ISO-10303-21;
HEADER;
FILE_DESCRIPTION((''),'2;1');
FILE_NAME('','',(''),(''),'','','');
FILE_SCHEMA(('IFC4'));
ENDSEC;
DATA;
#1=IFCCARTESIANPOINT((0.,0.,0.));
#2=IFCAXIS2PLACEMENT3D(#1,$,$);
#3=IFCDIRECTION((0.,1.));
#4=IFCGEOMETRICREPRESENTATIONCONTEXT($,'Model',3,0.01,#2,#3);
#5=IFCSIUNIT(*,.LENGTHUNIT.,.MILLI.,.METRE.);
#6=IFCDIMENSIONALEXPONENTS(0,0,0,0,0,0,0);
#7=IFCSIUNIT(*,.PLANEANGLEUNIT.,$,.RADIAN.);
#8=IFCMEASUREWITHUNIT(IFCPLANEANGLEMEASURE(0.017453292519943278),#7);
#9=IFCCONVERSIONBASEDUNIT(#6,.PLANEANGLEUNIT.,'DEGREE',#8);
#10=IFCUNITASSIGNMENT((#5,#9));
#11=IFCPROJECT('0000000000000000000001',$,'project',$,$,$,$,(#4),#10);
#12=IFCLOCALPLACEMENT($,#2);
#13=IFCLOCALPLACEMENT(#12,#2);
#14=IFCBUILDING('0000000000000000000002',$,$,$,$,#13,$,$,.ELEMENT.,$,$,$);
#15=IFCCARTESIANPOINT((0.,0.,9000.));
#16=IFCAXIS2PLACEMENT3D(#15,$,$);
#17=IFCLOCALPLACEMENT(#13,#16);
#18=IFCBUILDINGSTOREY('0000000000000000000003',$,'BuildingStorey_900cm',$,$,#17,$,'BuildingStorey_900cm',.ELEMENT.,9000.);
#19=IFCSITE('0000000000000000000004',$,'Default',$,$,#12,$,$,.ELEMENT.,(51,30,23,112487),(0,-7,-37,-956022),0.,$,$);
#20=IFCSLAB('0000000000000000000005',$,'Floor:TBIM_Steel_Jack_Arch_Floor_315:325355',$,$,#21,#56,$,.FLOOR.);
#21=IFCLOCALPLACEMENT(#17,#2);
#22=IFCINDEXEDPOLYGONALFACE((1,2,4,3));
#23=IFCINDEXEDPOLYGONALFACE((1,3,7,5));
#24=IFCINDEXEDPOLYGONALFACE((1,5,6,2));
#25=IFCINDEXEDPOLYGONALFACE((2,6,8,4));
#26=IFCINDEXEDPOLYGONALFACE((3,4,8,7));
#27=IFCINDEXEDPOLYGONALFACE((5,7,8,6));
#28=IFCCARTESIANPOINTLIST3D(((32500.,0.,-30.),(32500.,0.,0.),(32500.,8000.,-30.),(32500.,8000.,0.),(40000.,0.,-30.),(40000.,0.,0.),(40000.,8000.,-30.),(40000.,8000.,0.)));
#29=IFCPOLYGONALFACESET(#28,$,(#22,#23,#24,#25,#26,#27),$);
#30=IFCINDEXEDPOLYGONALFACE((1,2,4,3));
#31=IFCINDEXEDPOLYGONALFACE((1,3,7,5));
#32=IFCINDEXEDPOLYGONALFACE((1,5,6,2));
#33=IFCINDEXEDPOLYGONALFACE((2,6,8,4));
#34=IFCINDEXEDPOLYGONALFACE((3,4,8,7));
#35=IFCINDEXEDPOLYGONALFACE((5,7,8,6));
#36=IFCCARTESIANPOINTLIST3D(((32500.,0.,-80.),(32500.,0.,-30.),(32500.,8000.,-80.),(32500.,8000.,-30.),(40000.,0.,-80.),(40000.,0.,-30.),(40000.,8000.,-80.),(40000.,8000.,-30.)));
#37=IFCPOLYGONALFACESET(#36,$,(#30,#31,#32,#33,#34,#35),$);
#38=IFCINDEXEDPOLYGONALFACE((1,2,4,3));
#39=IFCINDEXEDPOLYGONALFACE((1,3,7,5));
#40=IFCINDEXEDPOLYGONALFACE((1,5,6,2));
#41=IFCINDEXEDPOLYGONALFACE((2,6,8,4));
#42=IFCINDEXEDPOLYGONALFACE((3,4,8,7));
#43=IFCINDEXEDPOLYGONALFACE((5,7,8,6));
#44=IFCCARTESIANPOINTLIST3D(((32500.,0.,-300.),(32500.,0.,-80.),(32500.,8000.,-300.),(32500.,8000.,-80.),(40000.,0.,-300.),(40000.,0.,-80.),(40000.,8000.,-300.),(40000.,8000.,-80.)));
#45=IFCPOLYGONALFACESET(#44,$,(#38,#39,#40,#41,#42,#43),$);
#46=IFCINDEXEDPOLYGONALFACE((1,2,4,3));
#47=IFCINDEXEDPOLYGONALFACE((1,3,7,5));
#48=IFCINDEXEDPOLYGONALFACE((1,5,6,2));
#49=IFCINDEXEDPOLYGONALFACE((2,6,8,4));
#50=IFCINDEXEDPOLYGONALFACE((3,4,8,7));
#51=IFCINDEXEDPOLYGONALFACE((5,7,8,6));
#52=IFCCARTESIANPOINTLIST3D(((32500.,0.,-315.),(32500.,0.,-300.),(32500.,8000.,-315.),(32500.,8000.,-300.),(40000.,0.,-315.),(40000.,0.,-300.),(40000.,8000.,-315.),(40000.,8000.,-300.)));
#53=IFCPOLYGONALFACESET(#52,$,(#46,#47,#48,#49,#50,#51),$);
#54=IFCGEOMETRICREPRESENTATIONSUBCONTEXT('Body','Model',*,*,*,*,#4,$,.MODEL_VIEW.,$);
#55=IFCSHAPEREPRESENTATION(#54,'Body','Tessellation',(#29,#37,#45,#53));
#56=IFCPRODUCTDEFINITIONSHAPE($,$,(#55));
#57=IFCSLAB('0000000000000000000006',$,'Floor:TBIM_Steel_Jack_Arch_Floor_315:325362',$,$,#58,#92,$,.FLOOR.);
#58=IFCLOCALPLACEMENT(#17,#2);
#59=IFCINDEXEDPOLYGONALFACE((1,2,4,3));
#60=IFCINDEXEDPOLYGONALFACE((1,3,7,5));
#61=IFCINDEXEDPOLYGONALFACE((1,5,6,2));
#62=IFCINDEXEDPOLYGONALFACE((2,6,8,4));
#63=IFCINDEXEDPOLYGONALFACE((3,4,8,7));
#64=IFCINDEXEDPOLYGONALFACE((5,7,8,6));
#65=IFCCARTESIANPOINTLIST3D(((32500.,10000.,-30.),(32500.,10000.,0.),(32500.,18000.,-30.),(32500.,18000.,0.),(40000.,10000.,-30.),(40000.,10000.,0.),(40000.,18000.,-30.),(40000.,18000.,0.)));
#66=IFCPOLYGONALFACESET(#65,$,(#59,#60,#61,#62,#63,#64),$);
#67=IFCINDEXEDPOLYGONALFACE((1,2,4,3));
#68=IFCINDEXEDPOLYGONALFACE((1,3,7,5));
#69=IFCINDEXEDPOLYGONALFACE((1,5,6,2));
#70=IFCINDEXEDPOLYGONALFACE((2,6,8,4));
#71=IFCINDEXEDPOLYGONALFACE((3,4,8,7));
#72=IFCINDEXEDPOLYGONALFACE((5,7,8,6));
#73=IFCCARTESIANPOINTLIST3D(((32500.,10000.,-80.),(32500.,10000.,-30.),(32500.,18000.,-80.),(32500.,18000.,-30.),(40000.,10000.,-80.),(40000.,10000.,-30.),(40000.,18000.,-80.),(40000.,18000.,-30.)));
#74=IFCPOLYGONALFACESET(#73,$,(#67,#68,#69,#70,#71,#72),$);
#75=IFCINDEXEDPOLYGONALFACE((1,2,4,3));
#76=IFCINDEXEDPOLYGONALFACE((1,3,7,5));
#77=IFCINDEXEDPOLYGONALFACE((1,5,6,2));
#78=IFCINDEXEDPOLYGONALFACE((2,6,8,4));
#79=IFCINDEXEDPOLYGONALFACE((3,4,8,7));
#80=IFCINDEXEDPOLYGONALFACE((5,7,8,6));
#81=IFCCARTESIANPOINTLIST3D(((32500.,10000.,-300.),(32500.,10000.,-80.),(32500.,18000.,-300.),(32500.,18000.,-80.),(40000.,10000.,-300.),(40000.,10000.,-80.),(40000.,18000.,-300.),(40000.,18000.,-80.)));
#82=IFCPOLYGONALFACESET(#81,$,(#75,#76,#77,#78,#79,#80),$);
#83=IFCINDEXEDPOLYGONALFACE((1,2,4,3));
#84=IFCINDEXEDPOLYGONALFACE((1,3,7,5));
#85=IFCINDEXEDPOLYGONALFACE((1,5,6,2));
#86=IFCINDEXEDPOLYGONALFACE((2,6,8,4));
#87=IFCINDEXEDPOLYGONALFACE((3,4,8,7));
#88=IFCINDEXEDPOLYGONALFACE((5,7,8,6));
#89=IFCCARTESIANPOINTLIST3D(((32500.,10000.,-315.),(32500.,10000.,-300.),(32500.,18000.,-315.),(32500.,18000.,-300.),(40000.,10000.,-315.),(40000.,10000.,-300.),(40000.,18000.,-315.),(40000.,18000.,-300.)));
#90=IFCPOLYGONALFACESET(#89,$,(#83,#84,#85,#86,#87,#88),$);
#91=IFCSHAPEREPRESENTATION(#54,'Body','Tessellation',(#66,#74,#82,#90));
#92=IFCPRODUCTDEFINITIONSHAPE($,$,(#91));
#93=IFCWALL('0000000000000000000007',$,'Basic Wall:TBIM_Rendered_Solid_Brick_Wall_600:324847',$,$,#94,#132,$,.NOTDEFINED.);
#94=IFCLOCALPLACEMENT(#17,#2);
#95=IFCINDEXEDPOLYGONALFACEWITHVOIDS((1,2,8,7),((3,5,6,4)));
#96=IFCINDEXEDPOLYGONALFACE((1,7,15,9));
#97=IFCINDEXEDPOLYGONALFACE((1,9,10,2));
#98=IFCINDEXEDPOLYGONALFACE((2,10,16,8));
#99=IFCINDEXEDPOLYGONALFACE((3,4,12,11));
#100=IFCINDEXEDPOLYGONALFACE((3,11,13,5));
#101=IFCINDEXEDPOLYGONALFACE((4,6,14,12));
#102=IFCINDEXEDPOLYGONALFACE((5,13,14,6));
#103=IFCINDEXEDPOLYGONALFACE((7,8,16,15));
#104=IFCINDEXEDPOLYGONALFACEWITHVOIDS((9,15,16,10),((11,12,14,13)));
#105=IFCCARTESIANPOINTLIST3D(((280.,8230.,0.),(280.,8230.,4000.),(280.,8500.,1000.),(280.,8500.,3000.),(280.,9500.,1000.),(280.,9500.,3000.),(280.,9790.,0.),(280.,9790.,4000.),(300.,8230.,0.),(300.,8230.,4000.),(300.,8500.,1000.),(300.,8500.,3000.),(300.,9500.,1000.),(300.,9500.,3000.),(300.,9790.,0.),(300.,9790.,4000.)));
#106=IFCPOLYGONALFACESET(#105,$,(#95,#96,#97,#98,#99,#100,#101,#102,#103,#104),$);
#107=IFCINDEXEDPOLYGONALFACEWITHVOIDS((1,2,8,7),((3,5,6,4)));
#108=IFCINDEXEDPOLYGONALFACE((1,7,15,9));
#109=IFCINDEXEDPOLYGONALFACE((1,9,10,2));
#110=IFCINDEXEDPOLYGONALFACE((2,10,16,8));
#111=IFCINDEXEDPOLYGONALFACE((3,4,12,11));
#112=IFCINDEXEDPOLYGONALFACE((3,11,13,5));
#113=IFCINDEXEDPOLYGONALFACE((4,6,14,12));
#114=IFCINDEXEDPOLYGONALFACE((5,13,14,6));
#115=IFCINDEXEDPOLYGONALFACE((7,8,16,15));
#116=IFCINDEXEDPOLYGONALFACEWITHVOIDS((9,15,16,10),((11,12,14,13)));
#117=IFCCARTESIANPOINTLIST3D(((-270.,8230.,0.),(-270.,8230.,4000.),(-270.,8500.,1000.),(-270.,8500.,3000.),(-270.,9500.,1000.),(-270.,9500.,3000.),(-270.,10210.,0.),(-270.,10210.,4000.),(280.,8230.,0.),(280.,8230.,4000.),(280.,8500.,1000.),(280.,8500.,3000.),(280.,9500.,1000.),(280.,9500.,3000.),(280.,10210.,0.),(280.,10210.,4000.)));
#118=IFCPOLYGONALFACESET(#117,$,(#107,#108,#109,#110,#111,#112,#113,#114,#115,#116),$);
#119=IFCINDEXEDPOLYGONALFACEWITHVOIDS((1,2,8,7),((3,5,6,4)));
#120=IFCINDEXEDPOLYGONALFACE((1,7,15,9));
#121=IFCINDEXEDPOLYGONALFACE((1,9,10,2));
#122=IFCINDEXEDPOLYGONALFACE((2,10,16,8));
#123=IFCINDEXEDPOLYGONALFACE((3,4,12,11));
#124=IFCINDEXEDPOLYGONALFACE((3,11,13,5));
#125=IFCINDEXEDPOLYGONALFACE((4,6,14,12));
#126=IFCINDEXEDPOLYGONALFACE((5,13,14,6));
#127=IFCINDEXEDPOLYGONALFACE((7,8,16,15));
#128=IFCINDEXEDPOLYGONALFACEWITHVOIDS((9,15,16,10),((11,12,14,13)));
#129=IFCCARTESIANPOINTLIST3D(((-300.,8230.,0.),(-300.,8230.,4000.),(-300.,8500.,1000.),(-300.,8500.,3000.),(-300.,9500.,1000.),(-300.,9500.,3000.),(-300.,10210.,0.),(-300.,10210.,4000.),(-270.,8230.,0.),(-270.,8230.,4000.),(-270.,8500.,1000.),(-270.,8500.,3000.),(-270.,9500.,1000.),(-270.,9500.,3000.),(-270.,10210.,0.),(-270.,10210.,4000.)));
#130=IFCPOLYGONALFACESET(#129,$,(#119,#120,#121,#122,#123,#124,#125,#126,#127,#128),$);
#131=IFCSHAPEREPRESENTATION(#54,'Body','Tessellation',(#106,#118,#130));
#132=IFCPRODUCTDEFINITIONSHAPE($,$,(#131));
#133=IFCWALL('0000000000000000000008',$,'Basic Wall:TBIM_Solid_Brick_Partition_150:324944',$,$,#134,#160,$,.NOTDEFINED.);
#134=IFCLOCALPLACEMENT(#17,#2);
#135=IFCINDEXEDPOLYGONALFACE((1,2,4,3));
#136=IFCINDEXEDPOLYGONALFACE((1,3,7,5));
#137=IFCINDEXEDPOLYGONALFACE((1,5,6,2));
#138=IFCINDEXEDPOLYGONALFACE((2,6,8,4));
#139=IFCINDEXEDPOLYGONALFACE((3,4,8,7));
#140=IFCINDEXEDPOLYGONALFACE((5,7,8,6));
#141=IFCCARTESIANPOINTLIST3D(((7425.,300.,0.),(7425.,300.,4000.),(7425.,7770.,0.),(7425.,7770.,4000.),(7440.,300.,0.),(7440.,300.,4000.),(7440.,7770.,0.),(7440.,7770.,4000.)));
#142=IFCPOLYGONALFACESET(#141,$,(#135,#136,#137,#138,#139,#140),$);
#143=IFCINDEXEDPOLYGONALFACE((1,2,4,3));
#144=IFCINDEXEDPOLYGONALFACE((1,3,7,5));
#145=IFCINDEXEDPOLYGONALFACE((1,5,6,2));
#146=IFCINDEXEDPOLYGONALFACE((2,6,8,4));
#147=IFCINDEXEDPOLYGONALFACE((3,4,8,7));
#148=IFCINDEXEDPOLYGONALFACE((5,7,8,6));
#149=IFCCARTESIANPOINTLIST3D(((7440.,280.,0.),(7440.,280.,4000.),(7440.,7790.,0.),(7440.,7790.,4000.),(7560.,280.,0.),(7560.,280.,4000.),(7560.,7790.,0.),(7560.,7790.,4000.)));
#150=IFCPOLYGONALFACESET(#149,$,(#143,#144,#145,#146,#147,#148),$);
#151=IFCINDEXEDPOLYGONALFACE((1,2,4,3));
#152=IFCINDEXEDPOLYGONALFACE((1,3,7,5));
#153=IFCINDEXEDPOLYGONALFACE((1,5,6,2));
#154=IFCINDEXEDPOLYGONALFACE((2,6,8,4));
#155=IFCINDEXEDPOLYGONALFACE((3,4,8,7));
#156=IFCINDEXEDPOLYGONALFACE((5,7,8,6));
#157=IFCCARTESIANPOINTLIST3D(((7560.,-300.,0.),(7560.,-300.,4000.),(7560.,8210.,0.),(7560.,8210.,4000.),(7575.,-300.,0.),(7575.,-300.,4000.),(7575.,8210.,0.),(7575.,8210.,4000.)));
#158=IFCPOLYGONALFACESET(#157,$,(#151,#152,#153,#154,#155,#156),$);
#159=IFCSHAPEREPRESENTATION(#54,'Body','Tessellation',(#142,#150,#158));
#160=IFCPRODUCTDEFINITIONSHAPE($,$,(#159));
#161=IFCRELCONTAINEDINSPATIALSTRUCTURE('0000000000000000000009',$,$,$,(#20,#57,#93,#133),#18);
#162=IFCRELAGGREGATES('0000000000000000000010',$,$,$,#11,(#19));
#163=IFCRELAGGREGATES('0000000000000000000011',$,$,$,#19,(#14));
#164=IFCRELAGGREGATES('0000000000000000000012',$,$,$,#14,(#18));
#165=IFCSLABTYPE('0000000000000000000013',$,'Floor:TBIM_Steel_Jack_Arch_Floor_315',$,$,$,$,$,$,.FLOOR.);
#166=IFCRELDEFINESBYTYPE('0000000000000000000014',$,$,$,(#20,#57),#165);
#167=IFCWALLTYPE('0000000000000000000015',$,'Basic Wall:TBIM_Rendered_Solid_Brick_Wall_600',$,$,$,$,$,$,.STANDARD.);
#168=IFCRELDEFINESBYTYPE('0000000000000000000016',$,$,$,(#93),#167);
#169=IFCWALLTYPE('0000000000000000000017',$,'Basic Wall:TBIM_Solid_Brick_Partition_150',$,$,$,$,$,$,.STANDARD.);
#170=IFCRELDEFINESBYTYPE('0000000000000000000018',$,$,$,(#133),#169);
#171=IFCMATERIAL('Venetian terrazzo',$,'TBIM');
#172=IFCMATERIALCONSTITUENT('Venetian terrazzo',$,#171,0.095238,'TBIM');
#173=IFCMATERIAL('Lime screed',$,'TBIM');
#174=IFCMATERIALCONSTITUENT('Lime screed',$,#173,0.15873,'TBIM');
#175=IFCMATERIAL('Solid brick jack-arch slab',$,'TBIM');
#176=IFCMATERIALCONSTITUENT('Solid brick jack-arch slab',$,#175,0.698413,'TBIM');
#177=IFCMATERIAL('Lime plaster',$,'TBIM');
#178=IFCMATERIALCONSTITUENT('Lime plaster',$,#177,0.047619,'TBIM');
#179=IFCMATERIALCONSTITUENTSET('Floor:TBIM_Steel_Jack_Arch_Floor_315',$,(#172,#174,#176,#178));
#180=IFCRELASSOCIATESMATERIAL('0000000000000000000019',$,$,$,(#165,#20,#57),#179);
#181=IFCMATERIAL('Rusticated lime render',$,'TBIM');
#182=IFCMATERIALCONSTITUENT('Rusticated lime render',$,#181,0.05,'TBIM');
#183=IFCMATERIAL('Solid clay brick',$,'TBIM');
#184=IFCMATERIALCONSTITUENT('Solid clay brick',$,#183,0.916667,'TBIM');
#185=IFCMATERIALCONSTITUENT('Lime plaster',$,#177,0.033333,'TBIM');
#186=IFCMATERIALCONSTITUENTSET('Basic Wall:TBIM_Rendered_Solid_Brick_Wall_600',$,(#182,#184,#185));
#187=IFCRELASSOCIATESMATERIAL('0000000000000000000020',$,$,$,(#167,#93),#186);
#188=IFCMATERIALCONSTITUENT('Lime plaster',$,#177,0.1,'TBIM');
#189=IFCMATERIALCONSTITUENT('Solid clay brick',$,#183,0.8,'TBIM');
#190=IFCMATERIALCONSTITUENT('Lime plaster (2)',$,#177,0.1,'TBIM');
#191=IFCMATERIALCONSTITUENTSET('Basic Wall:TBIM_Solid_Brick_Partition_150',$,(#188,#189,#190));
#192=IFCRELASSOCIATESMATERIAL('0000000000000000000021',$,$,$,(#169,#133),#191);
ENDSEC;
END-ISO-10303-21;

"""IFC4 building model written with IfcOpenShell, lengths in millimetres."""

from ifc_helpers import new_model, entity, si_unit, converted_unit, direction, frame, origin, place, context, subcontext, project, spatial, indexed_curve, outline, extrude, material, constituent, constituent_set, type_object, element, save


model = new_model("IFC4")

# Units and contexts
model_context = context("Model", 3, precision=0.01, world=origin(), true_north=direction((0.0, 1.0)))
body_context = subcontext(model_context, "Body", "Model", "MODEL_VIEW")
ifc_project = project(units=[si_unit("LENGTHUNIT", "METRE", prefix="MILLI"), converted_unit("PLANEANGLEUNIT", "DEGREE", entity("IfcPlaneAngleMeasure", 0.017453292519943278), si_unit("PLANEANGLEUNIT", "RADIAN"), dimensions=[0, 0, 0, 0, 0, 0, 0])], contexts=[model_context])

# Site, building, storey
site_placement = place(None, origin())
site = spatial("IfcSite", under=ifc_project, at=site_placement, Name="Default", CompositionType="ELEMENT", RefLatitude=(51, 30, 23, 112487), RefLongitude=(0, -7, -37, -956022), RefElevation=0.0)
building_placement = place(site_placement, origin())
building = spatial("IfcBuilding", under=site, at=building_placement, CompositionType="ELEMENT")
storey_placement = place(building_placement, frame((0.0, 0.0, 9000.0)))
storey = spatial("IfcBuildingStorey", under=building, at=storey_placement, Name="BuildingStorey_900cm", LongName="BuildingStorey_900cm", CompositionType="ELEMENT", Elevation=9000.0)

# Slabs
ifc_material_1 = material(Name="Venetian terrazzo", Category="TBIM")
ifc_constituent_1 = constituent(ifc_material_1, Name="Venetian terrazzo", Category="TBIM", fraction=0.095238)
ifc_material_2 = material(Name="Lime screed", Category="TBIM")
ifc_constituent_2 = constituent(ifc_material_2, Name="Lime screed", Category="TBIM", fraction=0.15873)
ifc_material_3 = material(Name="Solid brick jack-arch slab", Category="TBIM")
ifc_constituent_3 = constituent(ifc_material_3, Name="Solid brick jack-arch slab", Category="TBIM", fraction=0.698413)
ifc_material_4 = material(Name="Lime plaster", Category="TBIM")
ifc_constituent_4 = constituent(ifc_material_4, Name="Lime plaster", Category="TBIM", fraction=0.047619)
ifc_constituent_set_1 = constituent_set(constituents=[ifc_constituent_1, ifc_constituent_2, ifc_constituent_3, ifc_constituent_4], Name="Floor:TBIM_Steel_Jack_Arch_Floor_315")
slab_type = type_object("IfcSlabType", Name="Floor:TBIM_Steel_Jack_Arch_Floor_315", PredefinedType="FLOOR", material=ifc_constituent_set_1)
slab_1_placement = place(storey_placement, origin())
element("IfcSlab", 1, at=slab_1_placement, inside=storey, type_object=slab_type, material=ifc_constituent_set_1, Name="Floor:TBIM_Steel_Jack_Arch_Floor_315:325355", PredefinedType="FLOOR", context=body_context, shape_type="SweptSolid", body=[
    extrude(outline(indexed_curve([(-3750.0, -4000.0), (3750.0, -4000.0), (3750.0, 4000.0), (-3750.0, 4000.0), (-3750.0, -4000.0)], self_intersect=False)), frame((36250.0, 4000.0, -30.0), z_axis=(0.0, 0.0, 1.0), x_axis=(-1.0, 0.0, 0.0)), (0.0, 0.0, 1.0), 30.0),
    extrude(outline(indexed_curve([(-3750.0, -4000.0), (3750.0, -4000.0), (3750.0, 4000.0), (-3750.0, 4000.0), (-3750.0, -4000.0)], self_intersect=False)), frame((36250.0, 4000.0, -80.0), z_axis=(0.0, 0.0, 1.0), x_axis=(-1.0, 0.0, 0.0)), (0.0, 0.0, 1.0), 50.0),
    extrude(outline(indexed_curve([(-3750.0, -4000.0), (3750.0, -4000.0), (3750.0, 4000.0), (-3750.0, 4000.0), (-3750.0, -4000.0)], self_intersect=False)), frame((36250.0, 4000.0, -300.0), z_axis=(0.0, 0.0, 1.0), x_axis=(-1.0, 0.0, 0.0)), (0.0, 0.0, 1.0), 220.0),
    extrude(outline(indexed_curve([(-3750.0, -4000.0), (3750.0, -4000.0), (3750.0, 4000.0), (-3750.0, 4000.0), (-3750.0, -4000.0)], self_intersect=False)), frame((36250.0, 4000.0, -315.0), z_axis=(0.0, 0.0, 1.0), x_axis=(-1.0, 0.0, 0.0)), (0.0, 0.0, 1.0), 15.0),
])
slab_2_placement = place(storey_placement, origin())
element("IfcSlab", 2, at=slab_2_placement, inside=storey, type_object=slab_type, material=ifc_constituent_set_1, Name="Floor:TBIM_Steel_Jack_Arch_Floor_315:325362", PredefinedType="FLOOR", context=body_context, shape_type="SweptSolid", body=[
    extrude(outline(indexed_curve([(-3750.0, -4000.0), (3750.0, -4000.0), (3750.0, 4000.0), (-3750.0, 4000.0), (-3750.0, -4000.0)], self_intersect=False)), frame((36250.0, 14000.0, -30.0), z_axis=(0.0, 0.0, 1.0), x_axis=(-1.0, 0.0, 0.0)), (0.0, 0.0, 1.0), 30.0),
    extrude(outline(indexed_curve([(-3750.0, -4000.0), (3750.0, -4000.0), (3750.0, 4000.0), (-3750.0, 4000.0), (-3750.0, -4000.0)], self_intersect=False)), frame((36250.0, 14000.0, -80.0), z_axis=(0.0, 0.0, 1.0), x_axis=(-1.0, 0.0, 0.0)), (0.0, 0.0, 1.0), 50.0),
    extrude(outline(indexed_curve([(-3750.0, -4000.0), (3750.0, -4000.0), (3750.0, 4000.0), (-3750.0, 4000.0), (-3750.0, -4000.0)], self_intersect=False)), frame((36250.0, 14000.0, -300.0), z_axis=(0.0, 0.0, 1.0), x_axis=(-1.0, 0.0, 0.0)), (0.0, 0.0, 1.0), 220.0),
    extrude(outline(indexed_curve([(-3750.0, -4000.0), (3750.0, -4000.0), (3750.0, 4000.0), (-3750.0, 4000.0), (-3750.0, -4000.0)], self_intersect=False)), frame((36250.0, 14000.0, -315.0), z_axis=(0.0, 0.0, 1.0), x_axis=(-1.0, 0.0, 0.0)), (0.0, 0.0, 1.0), 15.0),
])

# Wall, opening
ifc_material_5 = material(Name="Rusticated lime render", Category="TBIM")
ifc_constituent_5 = constituent(ifc_material_5, Name="Rusticated lime render", Category="TBIM", fraction=0.05)
ifc_material_6 = material(Name="Solid clay brick", Category="TBIM")
ifc_constituent_6 = constituent(ifc_material_6, Name="Solid clay brick", Category="TBIM", fraction=0.916667)
ifc_constituent_7 = constituent(ifc_material_4, Name="Lime plaster", Category="TBIM", fraction=0.033333)
ifc_constituent_set_2 = constituent_set(constituents=[ifc_constituent_5, ifc_constituent_6, ifc_constituent_7], Name="Basic Wall:TBIM_Rendered_Solid_Brick_Wall_600")
wall_type_1 = type_object("IfcWallType", Name="Basic Wall:TBIM_Rendered_Solid_Brick_Wall_600", PredefinedType="STANDARD", material=ifc_constituent_set_2)
wall_1_placement = place(storey_placement, frame((0.0, 10230.0, 0.0), z_axis=(0.0, 0.0, 1.0), x_axis=(0.0, -1.0, 0.0)))
wall_1 = element("IfcWall", 3, at=wall_1_placement, inside=storey, type_object=wall_type_1, material=ifc_constituent_set_2, Name="Basic Wall:TBIM_Rendered_Solid_Brick_Wall_600:324847", PredefinedType="NOTDEFINED", context=body_context, shape_type="SweptSolid", body=[
    extrude(outline(indexed_curve([(-2000.0, -780.0), (2000.0, -780.0), (2000.0, 780.0), (-2000.0, 780.0), (-2000.0, -780.0)], self_intersect=False), holes=[indexed_curve([(-1000.0, -490.0), (-1000.0, 510.0), (1000.0, 510.0), (1000.0, -490.0), (-1000.0, -490.0)], self_intersect=False)]), frame((1220.0, 280.0, 2000.0), z_axis=(0.0, 1.0, 0.0), x_axis=(0.0, 0.0, 1.0)), (0.0, 0.0, 1.0), 20.0),
    extrude(outline(indexed_curve([(-2000.0, -990.0), (2000.0, -990.0), (2000.0, 990.0), (-2000.0, 990.0), (-2000.0, -990.0)], self_intersect=False), holes=[indexed_curve([(-1000.0, -280.0), (-1000.0, 720.0), (1000.0, 720.0), (1000.0, -280.0), (-1000.0, -280.0)], self_intersect=False)]), frame((1010.0, -270.0, 2000.0), z_axis=(0.0, 1.0, 0.0), x_axis=(0.0, 0.0, 1.0)), (0.0, 0.0, 1.0), 550.0),
    extrude(outline(indexed_curve([(-2000.0, -990.0), (2000.0, -990.0), (2000.0, 990.0), (-2000.0, 990.0), (-2000.0, -990.0)], self_intersect=False), holes=[indexed_curve([(1000.0, -280.0), (-1000.0, -280.0), (-1000.0, 720.0), (1000.0, 720.0), (1000.0, -280.0)], self_intersect=False)]), frame((1010.0, -300.0, 2000.0), z_axis=(0.0, 1.0, 0.0), x_axis=(0.0, 0.0, 1.0)), (0.0, 0.0, 1.0), 30.0),
])
opening_1_placement = place(wall_1_placement, frame((730.0, -300.0, 1000.0)))
element("IfcOpeningElement", 4, at=opening_1_placement, cuts=wall_1, PredefinedType="OPENING", context=body_context, shape_type="SweptSolid", body=[
    extrude(outline(indexed_curve([(2000.0, 0.0), (2000.0, 1000.0), (0.0, 1000.0), (0.0, 0.0), (2000.0, 0.0)], self_intersect=False)), frame((0.0, 0.0, 0.0), z_axis=(0.0, 1.0, 0.0), x_axis=(0.0, 0.0, 1.0)), (0.0, 0.0, 1.0), 600.0),
])

# Wall
ifc_constituent_8 = constituent(ifc_material_4, Name="Lime plaster", Category="TBIM", fraction=0.1)
ifc_constituent_9 = constituent(ifc_material_6, Name="Solid clay brick", Category="TBIM", fraction=0.8)
ifc_constituent_10 = constituent(ifc_material_4, Name="Lime plaster (2)", Category="TBIM", fraction=0.1)
ifc_constituent_set_3 = constituent_set(constituents=[ifc_constituent_8, ifc_constituent_9, ifc_constituent_10], Name="Basic Wall:TBIM_Solid_Brick_Partition_150")
wall_type_2 = type_object("IfcWallType", Name="Basic Wall:TBIM_Solid_Brick_Partition_150", PredefinedType="STANDARD", material=ifc_constituent_set_3)
wall_2_placement = place(storey_placement, frame((7500.0, 300.0, 0.0), z_axis=(0.0, 0.0, 1.0), x_axis=(0.0, 1.0, 0.0)))
element("IfcWall", 5, at=wall_2_placement, inside=storey, type_object=wall_type_2, material=ifc_constituent_set_3, Name="Basic Wall:TBIM_Solid_Brick_Partition_150:324944", PredefinedType="NOTDEFINED", context=body_context, shape_type="SweptSolid", body=[
    extrude(outline(indexed_curve([(-7.5, -3735.0), (7.5, -3735.0), (7.5, 3735.0), (-7.5, 3735.0), (-7.5, -3735.0)], self_intersect=False)), frame((3735.0, 67.5, 0.0), z_axis=(0.0, 0.0, 1.0), x_axis=(0.0, -1.0, 0.0)), (0.0, 0.0, 1.0), 4000.0),
    extrude(outline(indexed_curve([(-3755.0, -60.0), (3755.0, -60.0), (3755.0, 60.0), (-3755.0, 60.0), (-3755.0, -60.0)], self_intersect=False)), frame((3735.0, 0.0, 0.0)), (0.0, 0.0, 1.0), 4000.0),
    extrude(outline(indexed_curve([(-7.5, -4255.0), (7.5, -4255.0), (7.5, 4255.0), (-7.5, 4255.0), (-7.5, -4255.0)], self_intersect=False)), frame((3655.0, -67.5, 0.0), z_axis=(0.0, 0.0, 1.0), x_axis=(0.0, 1.0, 0.0)), (0.0, 0.0, 1.0), 4000.0),
])

save(model, "model.ifc")
